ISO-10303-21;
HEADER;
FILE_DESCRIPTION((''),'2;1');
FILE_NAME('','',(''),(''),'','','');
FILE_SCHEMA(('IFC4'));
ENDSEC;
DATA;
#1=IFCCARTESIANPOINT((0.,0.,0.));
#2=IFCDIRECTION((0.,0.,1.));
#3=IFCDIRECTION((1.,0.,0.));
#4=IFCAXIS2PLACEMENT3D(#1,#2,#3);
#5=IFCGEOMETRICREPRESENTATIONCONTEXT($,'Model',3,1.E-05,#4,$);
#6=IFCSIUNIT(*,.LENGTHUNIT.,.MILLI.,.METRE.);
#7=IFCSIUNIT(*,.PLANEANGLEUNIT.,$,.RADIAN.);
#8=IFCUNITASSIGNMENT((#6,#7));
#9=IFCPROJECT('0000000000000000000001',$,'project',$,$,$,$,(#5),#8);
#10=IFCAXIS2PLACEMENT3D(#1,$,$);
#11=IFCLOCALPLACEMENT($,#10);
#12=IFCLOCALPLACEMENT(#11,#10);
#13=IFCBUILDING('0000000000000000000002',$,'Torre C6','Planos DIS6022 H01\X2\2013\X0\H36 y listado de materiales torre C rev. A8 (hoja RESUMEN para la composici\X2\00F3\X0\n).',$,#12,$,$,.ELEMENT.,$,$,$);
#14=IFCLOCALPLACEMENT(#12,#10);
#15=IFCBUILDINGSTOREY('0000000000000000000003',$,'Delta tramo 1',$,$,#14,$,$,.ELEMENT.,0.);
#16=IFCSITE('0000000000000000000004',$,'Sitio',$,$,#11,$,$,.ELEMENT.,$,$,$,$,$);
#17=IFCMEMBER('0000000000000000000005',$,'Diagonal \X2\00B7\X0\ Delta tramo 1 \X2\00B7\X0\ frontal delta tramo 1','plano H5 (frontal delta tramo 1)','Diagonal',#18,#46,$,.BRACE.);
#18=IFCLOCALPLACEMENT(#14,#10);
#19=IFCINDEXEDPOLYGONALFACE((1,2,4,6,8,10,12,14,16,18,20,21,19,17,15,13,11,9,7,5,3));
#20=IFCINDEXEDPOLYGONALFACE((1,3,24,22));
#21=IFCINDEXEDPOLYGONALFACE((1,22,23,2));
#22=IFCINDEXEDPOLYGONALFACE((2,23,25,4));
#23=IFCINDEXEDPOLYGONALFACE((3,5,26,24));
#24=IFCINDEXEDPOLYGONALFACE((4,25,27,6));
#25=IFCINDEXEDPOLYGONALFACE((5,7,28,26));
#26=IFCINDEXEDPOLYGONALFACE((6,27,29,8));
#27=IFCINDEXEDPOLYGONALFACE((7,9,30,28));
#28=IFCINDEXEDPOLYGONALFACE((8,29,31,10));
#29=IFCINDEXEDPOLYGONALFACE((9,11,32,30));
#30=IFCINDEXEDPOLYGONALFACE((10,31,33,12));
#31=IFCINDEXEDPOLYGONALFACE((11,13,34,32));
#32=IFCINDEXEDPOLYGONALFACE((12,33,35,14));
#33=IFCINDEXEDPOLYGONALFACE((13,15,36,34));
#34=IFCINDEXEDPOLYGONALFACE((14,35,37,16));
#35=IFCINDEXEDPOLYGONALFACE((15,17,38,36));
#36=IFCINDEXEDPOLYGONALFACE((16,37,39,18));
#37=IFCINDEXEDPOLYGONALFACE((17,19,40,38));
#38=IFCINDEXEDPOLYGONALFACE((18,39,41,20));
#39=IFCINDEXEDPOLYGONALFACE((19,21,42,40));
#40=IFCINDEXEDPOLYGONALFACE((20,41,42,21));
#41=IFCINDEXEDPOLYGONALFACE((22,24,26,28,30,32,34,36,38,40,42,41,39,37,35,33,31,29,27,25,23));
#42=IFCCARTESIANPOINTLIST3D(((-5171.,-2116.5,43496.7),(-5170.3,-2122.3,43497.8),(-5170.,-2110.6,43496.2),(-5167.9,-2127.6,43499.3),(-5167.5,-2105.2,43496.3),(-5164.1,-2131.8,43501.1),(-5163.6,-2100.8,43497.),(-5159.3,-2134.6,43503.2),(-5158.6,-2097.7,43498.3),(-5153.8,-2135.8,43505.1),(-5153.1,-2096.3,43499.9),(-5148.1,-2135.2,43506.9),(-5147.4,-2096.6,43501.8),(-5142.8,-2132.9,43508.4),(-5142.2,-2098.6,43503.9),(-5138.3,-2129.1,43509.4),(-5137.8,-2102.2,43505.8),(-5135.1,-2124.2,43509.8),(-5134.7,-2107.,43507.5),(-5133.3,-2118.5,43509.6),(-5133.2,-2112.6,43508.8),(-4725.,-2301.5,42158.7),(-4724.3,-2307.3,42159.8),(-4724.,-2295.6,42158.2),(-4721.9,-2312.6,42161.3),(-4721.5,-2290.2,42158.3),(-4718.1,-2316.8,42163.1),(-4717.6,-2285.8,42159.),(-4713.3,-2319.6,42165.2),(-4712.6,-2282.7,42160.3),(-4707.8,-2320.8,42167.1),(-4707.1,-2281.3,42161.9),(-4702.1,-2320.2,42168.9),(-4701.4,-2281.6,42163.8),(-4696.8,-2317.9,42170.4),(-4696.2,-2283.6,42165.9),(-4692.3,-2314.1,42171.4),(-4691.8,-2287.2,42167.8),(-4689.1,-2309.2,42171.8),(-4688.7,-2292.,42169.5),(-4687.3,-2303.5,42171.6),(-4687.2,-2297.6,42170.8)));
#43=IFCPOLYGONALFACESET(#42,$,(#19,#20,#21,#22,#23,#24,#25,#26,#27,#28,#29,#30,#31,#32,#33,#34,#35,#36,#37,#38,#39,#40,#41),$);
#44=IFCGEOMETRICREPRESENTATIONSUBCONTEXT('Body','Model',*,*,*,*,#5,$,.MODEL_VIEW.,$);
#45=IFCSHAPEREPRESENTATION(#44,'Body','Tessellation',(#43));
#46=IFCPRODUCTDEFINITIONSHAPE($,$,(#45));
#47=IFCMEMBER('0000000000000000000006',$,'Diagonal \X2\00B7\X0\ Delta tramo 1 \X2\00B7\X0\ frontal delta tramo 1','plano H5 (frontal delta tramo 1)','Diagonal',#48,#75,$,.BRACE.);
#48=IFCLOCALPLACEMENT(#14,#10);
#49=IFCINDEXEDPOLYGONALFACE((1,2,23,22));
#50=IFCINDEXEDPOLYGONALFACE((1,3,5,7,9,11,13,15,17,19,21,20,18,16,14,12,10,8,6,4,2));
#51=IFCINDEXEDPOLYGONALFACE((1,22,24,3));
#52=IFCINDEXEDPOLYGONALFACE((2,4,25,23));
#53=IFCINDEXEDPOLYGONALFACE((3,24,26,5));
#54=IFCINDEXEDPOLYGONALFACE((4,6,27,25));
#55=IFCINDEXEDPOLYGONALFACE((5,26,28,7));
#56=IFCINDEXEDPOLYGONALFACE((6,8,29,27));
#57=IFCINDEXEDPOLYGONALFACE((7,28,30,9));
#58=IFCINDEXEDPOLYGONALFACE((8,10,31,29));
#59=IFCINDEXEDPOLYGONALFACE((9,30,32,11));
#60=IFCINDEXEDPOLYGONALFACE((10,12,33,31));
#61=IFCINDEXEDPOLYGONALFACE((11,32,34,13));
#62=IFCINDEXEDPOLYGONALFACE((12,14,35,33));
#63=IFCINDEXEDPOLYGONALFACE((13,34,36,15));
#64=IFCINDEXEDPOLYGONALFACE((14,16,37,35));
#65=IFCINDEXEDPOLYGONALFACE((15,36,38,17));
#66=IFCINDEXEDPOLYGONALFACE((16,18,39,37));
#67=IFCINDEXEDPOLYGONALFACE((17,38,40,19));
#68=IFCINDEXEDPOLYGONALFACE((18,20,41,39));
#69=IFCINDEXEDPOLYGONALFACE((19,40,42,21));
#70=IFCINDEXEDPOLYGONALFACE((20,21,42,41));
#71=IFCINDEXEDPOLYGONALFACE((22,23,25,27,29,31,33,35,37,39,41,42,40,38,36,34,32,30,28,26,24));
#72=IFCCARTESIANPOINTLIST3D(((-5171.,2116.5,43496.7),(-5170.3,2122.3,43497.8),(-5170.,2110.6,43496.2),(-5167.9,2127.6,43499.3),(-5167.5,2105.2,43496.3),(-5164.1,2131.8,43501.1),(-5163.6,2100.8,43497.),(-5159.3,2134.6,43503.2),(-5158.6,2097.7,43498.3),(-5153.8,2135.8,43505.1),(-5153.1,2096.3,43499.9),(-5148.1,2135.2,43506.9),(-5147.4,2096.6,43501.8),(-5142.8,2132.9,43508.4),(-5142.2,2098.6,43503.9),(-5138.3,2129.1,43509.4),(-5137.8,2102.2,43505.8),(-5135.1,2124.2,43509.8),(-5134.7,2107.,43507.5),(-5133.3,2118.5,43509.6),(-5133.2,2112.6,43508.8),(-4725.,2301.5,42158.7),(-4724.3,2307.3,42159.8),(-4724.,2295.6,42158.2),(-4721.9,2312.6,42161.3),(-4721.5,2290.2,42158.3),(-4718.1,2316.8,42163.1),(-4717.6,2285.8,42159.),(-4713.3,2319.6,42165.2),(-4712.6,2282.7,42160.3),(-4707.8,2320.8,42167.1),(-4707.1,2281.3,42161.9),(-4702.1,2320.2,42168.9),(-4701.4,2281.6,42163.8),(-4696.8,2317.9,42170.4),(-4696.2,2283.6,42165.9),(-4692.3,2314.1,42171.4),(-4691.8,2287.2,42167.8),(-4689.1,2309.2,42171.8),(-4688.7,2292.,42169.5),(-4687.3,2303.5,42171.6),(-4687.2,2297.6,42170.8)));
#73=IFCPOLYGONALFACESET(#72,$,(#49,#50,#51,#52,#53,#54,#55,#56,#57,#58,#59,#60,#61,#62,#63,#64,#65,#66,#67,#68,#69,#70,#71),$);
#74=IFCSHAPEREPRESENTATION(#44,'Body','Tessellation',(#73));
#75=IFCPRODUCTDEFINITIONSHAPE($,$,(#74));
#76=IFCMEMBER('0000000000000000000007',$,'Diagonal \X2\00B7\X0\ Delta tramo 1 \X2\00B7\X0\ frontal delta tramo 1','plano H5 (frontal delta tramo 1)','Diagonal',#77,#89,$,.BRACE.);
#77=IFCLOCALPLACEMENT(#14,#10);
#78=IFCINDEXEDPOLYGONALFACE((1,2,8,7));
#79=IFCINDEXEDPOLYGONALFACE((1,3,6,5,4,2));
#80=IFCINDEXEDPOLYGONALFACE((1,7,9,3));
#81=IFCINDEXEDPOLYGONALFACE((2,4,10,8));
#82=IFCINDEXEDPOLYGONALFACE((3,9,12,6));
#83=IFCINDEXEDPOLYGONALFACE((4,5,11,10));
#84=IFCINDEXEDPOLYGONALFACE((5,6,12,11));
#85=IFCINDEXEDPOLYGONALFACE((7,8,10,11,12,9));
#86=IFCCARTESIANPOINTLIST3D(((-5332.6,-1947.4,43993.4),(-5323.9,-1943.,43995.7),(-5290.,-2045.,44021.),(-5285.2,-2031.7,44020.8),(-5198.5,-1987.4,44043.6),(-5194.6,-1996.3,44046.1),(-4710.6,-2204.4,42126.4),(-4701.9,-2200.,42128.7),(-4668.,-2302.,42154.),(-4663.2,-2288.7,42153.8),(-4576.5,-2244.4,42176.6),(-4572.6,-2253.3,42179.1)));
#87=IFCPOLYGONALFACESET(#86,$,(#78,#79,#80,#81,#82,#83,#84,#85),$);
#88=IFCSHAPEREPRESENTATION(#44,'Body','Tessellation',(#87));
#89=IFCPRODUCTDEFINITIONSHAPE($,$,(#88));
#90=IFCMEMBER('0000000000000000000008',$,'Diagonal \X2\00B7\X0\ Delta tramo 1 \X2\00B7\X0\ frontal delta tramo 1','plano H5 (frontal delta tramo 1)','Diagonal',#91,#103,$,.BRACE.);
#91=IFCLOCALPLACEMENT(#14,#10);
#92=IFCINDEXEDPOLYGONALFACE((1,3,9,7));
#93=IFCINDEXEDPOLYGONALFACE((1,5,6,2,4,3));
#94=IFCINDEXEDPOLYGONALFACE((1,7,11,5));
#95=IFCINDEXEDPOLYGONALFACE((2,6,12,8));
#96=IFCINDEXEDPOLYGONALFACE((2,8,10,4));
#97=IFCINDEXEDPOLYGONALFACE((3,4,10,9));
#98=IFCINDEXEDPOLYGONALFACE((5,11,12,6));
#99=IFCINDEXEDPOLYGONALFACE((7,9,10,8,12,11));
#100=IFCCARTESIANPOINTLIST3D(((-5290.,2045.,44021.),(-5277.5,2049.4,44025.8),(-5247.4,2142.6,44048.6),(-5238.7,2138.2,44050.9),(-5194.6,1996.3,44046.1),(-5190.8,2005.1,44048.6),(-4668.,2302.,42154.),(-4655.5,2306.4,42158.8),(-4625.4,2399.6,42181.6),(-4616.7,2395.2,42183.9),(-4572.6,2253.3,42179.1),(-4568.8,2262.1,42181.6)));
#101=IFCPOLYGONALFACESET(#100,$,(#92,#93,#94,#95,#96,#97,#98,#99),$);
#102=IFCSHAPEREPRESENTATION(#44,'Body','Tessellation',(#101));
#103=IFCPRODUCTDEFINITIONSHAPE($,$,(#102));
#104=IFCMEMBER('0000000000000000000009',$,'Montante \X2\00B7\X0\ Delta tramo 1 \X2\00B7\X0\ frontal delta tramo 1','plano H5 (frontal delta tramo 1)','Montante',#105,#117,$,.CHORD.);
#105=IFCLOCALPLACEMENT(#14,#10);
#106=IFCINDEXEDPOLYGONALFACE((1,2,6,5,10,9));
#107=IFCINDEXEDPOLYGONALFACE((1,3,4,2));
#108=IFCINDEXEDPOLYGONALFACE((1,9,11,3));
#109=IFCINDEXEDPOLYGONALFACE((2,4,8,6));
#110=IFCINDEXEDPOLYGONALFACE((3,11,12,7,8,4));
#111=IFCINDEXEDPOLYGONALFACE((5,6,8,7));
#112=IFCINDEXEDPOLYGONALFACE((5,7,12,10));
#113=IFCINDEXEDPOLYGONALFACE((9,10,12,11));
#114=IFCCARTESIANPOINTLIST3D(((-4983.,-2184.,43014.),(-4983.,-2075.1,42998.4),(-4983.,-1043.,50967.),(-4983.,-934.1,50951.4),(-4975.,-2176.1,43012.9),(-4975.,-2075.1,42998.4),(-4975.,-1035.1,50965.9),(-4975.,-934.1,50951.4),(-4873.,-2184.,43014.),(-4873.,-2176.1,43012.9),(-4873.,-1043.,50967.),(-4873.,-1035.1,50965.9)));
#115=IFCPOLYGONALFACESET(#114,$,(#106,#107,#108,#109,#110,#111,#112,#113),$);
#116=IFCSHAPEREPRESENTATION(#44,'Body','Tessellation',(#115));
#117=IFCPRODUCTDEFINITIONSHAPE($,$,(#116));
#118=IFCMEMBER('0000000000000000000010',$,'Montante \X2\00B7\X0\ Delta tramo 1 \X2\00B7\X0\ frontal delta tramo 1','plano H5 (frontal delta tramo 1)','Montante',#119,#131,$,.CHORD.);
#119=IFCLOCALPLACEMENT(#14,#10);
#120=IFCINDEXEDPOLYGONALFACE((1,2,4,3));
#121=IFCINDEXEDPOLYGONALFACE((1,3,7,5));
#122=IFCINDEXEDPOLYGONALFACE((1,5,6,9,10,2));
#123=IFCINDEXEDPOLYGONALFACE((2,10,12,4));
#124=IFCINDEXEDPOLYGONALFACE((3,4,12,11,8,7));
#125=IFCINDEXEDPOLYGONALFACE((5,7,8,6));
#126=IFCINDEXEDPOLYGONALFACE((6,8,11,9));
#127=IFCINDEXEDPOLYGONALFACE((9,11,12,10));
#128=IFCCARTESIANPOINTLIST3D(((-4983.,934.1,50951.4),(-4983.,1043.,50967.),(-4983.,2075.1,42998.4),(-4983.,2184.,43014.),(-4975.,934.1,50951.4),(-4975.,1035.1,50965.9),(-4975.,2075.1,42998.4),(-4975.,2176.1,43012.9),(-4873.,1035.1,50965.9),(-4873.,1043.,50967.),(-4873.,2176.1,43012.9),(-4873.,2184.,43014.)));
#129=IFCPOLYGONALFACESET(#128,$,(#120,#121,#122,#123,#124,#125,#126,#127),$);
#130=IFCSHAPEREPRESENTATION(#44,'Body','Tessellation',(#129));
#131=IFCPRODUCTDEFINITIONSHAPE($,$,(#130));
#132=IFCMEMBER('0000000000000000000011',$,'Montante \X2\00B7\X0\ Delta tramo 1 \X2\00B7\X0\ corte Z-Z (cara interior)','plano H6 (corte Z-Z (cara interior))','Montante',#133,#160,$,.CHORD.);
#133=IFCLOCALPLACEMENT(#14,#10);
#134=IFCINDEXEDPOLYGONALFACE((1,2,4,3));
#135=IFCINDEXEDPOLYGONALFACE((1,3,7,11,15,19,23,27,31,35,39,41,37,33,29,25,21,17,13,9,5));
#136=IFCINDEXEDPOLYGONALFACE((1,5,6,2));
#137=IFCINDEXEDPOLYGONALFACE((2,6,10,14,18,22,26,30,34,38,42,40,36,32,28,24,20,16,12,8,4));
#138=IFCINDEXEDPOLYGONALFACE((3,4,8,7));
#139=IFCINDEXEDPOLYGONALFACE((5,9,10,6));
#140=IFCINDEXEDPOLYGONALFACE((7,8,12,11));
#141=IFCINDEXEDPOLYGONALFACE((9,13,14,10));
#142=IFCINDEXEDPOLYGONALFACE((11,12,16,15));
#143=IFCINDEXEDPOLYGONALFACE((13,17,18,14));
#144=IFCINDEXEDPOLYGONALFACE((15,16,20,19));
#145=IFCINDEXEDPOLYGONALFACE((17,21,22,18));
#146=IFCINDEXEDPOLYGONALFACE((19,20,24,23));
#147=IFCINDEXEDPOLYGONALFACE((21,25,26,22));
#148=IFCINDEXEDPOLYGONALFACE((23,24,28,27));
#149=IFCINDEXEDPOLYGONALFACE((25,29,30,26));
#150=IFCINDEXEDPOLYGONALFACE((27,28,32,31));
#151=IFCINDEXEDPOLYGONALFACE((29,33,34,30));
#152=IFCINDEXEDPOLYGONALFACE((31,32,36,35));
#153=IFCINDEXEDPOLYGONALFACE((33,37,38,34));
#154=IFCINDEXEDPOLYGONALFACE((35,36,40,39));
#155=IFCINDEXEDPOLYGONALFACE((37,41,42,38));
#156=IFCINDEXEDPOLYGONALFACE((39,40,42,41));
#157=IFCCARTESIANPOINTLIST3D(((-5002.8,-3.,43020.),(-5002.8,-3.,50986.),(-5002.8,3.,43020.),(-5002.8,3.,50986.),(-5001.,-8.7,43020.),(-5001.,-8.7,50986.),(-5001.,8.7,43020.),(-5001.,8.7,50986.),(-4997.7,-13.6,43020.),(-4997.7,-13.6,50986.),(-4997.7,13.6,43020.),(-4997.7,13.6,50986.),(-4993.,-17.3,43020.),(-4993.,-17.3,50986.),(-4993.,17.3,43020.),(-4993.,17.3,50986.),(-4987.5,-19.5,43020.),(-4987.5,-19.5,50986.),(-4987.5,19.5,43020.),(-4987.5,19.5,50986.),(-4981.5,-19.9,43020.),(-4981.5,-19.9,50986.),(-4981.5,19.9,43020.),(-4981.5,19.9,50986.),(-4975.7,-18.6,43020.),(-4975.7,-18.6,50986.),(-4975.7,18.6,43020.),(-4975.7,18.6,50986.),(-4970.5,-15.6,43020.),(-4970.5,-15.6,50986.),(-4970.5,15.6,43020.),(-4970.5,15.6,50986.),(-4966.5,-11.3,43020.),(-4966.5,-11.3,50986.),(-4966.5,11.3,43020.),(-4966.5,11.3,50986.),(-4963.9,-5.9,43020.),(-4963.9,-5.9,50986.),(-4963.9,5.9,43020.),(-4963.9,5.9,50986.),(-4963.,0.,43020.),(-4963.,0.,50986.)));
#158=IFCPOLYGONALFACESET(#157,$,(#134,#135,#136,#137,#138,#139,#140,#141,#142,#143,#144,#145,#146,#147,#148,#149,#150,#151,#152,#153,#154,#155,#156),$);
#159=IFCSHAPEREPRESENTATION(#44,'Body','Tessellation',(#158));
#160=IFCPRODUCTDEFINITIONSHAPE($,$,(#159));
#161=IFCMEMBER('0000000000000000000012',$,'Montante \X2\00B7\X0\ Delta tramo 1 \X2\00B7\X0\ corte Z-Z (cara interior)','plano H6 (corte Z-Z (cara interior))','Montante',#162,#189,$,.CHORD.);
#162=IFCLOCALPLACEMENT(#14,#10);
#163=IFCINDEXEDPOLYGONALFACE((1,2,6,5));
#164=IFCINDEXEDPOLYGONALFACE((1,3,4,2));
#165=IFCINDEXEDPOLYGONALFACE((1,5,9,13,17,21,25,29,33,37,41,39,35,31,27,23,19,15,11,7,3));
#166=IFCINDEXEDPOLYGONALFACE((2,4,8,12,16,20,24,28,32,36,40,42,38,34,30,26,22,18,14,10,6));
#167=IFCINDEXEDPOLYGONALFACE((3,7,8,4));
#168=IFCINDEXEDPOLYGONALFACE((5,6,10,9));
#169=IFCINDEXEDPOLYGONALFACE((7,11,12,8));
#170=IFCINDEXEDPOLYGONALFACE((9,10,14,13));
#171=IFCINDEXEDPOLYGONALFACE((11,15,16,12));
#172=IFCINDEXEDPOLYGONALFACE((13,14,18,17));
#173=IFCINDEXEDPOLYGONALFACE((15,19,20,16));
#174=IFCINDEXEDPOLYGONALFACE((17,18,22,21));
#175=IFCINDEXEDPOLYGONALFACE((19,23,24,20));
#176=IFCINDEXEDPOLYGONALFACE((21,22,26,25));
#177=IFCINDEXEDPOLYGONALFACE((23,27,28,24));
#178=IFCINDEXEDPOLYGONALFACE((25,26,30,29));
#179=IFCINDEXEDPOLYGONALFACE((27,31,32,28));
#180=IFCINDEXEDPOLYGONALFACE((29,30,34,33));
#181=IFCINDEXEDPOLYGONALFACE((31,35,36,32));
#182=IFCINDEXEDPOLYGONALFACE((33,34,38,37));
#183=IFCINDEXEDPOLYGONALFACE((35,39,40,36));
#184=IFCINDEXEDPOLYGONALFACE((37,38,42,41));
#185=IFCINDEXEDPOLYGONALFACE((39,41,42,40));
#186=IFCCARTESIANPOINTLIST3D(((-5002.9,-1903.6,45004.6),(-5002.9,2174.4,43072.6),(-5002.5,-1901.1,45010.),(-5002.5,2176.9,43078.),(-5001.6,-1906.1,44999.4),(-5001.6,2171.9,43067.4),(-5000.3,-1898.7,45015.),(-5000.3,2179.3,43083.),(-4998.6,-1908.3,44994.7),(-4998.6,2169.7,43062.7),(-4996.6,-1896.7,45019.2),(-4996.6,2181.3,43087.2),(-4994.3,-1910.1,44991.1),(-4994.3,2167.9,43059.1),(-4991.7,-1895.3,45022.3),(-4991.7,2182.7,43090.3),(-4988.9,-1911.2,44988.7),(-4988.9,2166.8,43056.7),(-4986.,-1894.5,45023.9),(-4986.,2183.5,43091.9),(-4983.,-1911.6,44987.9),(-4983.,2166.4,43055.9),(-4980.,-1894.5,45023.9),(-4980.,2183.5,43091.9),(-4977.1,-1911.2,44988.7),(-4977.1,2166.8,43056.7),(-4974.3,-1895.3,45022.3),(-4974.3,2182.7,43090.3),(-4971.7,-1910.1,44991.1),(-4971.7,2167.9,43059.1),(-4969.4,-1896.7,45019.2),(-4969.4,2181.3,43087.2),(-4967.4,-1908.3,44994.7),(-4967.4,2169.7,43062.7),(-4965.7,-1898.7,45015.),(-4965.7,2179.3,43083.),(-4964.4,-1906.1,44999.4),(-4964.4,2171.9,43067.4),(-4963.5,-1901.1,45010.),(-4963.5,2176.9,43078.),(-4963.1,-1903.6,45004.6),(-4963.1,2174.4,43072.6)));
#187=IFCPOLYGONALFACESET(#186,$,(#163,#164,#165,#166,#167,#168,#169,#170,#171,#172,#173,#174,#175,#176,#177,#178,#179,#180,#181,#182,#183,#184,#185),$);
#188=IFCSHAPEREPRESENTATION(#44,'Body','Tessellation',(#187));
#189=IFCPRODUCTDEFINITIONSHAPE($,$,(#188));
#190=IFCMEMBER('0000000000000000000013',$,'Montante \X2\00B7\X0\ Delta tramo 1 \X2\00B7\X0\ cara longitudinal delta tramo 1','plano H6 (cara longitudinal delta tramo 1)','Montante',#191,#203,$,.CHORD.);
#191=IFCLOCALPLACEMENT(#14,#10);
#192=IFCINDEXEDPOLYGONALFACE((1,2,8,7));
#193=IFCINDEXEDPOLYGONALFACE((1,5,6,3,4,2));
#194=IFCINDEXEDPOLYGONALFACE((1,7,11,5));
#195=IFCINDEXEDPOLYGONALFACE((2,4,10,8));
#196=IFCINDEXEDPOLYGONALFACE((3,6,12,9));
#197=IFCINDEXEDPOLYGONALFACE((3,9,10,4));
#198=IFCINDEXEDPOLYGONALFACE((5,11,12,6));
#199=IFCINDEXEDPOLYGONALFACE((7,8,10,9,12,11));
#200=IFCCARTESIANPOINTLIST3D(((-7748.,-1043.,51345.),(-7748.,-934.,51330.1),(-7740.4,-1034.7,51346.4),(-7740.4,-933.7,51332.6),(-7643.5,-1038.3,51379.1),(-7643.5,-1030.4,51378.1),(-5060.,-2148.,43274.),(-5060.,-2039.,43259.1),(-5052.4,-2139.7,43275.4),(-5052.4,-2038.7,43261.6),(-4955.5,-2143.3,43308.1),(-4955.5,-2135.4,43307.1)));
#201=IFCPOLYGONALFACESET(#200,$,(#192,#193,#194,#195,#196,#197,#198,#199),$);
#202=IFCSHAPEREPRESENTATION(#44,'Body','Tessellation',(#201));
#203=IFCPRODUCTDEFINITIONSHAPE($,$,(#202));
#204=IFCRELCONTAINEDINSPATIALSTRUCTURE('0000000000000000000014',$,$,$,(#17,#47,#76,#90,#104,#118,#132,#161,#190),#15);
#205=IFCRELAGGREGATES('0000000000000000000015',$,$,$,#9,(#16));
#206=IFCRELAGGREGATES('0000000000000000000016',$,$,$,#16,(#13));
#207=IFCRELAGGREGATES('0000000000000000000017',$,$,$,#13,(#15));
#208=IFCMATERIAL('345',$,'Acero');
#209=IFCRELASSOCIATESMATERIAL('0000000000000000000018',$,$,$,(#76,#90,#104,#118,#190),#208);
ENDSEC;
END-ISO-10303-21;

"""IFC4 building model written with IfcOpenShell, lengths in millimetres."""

from ifc_helpers import new_model, si_unit, frame, frame_2d, origin, origin_with_axes, place, context, subcontext, project, spatial, circle, l_section, extrude, material, element, save


model = new_model("IFC4")

# Units and contexts
model_context = context("Model", 3, precision=1e-05, world=origin_with_axes())
body_context = subcontext(model_context, "Body", "Model", "MODEL_VIEW")
ifc_project = project(units=[si_unit("LENGTHUNIT", "METRE", prefix="MILLI"), si_unit("PLANEANGLEUNIT", "RADIAN")], contexts=[model_context])

# Site, building, storey
site_placement = place(None, origin())
site = spatial("IfcSite", under=ifc_project, at=site_placement, Name="Sitio", CompositionType="ELEMENT")
building_placement = place(site_placement, origin())
building = spatial("IfcBuilding", under=site, at=building_placement, Name="Torre C6", Description="Planos DIS6022 H01–H36 y listado de materiales torre C rev. A8 (hoja RESUMEN para la composición).", CompositionType="ELEMENT")
storey_placement = place(building_placement, origin())
storey = spatial("IfcBuildingStorey", under=building, at=storey_placement, Name="Delta tramo 1", CompositionType="ELEMENT", Elevation=0.0)

# Members
for number, where, z_axis, x_axis, name in (
    (1, (-4706.0, -2301.0, 42165.0), (-0.313542, 0.130057, 0.940626), (0.863292, 0.451616, 0.225321), "Diagonal · Delta tramo 1 · frontal delta tramo 1"),
    (2, (-4706.0, 2301.0, 42165.0), (-0.313542, -0.130057, 0.940626), (0.863292, -0.451616, 0.225321), "Diagonal · Delta tramo 1 · frontal delta tramo 1"),
):
    element("IfcMember", number, at=place(storey_placement, frame(where, z_axis=z_axis, x_axis=x_axis)), inside=storey, Name=name, Description="plano H5 (frontal delta tramo 1)", ObjectType="Diagonal", PredefinedType="BRACE", context=body_context, shape_type="SweptSolid", body=[
        extrude(circle(Radius=20.0), None, (0.0, 0.0, 1.0), 1422.5),
    ])
ifc_material_1 = material(Name="345", Category="Acero")
for number, where, z_axis, x_axis, name in (
    (3, (-4668.0, -2302.0, 42154.0), (-0.313414, 0.129497, 0.940746), (0.867067, 0.443015, 0.227885), "Diagonal · Delta tramo 1 · frontal delta tramo 1"),
    (4, (-4668.0, 2302.0, 42154.0), (-0.313414, -0.129497, 0.940746), (0.867067, -0.443015, 0.227885), "Diagonal · Delta tramo 1 · frontal delta tramo 1"),
):
    element("IfcMember", number, at=place(storey_placement, frame(where, z_axis=z_axis, x_axis=x_axis)), inside=storey, material=ifc_material_1, Name=name, Description="plano H5 (frontal delta tramo 1)", ObjectType="Diagonal", PredefinedType="BRACE", context=body_context, shape_type="SweptSolid", body=[
        extrude(l_section(Depth=110.0, Width=110.0, Thickness=10.0, at=frame_2d((55.0, 55.0))), None, (0.0, 0.0, 1.0), 1984.6),
    ])
for number, where, z_axis, x_axis, name in (
    (5, (-4983.0, -2184.0, 43014.0), (0.0, 0.142014, 0.989865), (1.0, 0.0, 0.0), "Montante · Delta tramo 1 · frontal delta tramo 1"),
    (6, (-4983.0, 2184.0, 43014.0), (0.0, -0.142014, 0.989865), (0.0, -0.989865, -0.142014), "Montante · Delta tramo 1 · frontal delta tramo 1"),
):
    element("IfcMember", number, at=place(storey_placement, frame(where, z_axis=z_axis, x_axis=x_axis)), inside=storey, material=ifc_material_1, Name=name, Description="plano H5 (frontal delta tramo 1)", ObjectType="Montante", PredefinedType="CHORD", context=body_context, shape_type="SweptSolid", body=[
        extrude(l_section(Depth=110.0, Width=110.0, Thickness=8.0, at=frame_2d((55.0, 55.0))), None, (0.0, 0.0, 1.0), 8034.4),
    ])
member_1_placement = place(storey_placement, frame((-4983.0, 0.0, 43020.0), z_axis=(0.0, 0.0, 1.0), x_axis=(1.0, 0.0, 0.0)))
element("IfcMember", 7, at=member_1_placement, inside=storey, Name="Montante · Delta tramo 1 · corte Z-Z (cara interior)", Description="plano H6 (corte Z-Z (cara interior))", ObjectType="Montante", PredefinedType="CHORD", context=body_context, shape_type="SweptSolid", body=[
    extrude(circle(Radius=20.0), None, (0.0, 0.0, 1.0), 7966.0),
])
member_2_placement = place(storey_placement, frame((-4983.0, 2175.0, 43074.0), z_axis=(0.0, -0.903711, 0.428144), x_axis=(0.0, -0.428144, -0.903711)))
element("IfcMember", 8, at=member_2_placement, inside=storey, Name="Montante · Delta tramo 1 · corte Z-Z (cara interior)", Description="plano H6 (corte Z-Z (cara interior))", ObjectType="Montante", PredefinedType="CHORD", context=body_context, shape_type="SweptSolid", body=[
    extrude(circle(Radius=20.0), None, (0.0, 0.0, 1.0), 4512.5),
])
member_3_placement = place(storey_placement, frame((-5060.0, -2148.0, 43274.0), z_axis=(-0.313348, 0.128813, 0.940861), x_axis=(0.949638, 0.042504, 0.310452)))
element("IfcMember", 9, at=member_3_placement, inside=storey, material=ifc_material_1, Name="Montante · Delta tramo 1 · cara longitudinal delta tramo 1", Description="plano H6 (cara longitudinal delta tramo 1)", ObjectType="Montante", PredefinedType="CHORD", context=body_context, shape_type="SweptSolid", body=[
    extrude(l_section(Depth=110.0, Width=110.0, Thickness=8.0, at=frame_2d((55.0, 55.0))), None, (0.0, 0.0, 1.0), 8578.3),
])

save(model, "model.ifc")
